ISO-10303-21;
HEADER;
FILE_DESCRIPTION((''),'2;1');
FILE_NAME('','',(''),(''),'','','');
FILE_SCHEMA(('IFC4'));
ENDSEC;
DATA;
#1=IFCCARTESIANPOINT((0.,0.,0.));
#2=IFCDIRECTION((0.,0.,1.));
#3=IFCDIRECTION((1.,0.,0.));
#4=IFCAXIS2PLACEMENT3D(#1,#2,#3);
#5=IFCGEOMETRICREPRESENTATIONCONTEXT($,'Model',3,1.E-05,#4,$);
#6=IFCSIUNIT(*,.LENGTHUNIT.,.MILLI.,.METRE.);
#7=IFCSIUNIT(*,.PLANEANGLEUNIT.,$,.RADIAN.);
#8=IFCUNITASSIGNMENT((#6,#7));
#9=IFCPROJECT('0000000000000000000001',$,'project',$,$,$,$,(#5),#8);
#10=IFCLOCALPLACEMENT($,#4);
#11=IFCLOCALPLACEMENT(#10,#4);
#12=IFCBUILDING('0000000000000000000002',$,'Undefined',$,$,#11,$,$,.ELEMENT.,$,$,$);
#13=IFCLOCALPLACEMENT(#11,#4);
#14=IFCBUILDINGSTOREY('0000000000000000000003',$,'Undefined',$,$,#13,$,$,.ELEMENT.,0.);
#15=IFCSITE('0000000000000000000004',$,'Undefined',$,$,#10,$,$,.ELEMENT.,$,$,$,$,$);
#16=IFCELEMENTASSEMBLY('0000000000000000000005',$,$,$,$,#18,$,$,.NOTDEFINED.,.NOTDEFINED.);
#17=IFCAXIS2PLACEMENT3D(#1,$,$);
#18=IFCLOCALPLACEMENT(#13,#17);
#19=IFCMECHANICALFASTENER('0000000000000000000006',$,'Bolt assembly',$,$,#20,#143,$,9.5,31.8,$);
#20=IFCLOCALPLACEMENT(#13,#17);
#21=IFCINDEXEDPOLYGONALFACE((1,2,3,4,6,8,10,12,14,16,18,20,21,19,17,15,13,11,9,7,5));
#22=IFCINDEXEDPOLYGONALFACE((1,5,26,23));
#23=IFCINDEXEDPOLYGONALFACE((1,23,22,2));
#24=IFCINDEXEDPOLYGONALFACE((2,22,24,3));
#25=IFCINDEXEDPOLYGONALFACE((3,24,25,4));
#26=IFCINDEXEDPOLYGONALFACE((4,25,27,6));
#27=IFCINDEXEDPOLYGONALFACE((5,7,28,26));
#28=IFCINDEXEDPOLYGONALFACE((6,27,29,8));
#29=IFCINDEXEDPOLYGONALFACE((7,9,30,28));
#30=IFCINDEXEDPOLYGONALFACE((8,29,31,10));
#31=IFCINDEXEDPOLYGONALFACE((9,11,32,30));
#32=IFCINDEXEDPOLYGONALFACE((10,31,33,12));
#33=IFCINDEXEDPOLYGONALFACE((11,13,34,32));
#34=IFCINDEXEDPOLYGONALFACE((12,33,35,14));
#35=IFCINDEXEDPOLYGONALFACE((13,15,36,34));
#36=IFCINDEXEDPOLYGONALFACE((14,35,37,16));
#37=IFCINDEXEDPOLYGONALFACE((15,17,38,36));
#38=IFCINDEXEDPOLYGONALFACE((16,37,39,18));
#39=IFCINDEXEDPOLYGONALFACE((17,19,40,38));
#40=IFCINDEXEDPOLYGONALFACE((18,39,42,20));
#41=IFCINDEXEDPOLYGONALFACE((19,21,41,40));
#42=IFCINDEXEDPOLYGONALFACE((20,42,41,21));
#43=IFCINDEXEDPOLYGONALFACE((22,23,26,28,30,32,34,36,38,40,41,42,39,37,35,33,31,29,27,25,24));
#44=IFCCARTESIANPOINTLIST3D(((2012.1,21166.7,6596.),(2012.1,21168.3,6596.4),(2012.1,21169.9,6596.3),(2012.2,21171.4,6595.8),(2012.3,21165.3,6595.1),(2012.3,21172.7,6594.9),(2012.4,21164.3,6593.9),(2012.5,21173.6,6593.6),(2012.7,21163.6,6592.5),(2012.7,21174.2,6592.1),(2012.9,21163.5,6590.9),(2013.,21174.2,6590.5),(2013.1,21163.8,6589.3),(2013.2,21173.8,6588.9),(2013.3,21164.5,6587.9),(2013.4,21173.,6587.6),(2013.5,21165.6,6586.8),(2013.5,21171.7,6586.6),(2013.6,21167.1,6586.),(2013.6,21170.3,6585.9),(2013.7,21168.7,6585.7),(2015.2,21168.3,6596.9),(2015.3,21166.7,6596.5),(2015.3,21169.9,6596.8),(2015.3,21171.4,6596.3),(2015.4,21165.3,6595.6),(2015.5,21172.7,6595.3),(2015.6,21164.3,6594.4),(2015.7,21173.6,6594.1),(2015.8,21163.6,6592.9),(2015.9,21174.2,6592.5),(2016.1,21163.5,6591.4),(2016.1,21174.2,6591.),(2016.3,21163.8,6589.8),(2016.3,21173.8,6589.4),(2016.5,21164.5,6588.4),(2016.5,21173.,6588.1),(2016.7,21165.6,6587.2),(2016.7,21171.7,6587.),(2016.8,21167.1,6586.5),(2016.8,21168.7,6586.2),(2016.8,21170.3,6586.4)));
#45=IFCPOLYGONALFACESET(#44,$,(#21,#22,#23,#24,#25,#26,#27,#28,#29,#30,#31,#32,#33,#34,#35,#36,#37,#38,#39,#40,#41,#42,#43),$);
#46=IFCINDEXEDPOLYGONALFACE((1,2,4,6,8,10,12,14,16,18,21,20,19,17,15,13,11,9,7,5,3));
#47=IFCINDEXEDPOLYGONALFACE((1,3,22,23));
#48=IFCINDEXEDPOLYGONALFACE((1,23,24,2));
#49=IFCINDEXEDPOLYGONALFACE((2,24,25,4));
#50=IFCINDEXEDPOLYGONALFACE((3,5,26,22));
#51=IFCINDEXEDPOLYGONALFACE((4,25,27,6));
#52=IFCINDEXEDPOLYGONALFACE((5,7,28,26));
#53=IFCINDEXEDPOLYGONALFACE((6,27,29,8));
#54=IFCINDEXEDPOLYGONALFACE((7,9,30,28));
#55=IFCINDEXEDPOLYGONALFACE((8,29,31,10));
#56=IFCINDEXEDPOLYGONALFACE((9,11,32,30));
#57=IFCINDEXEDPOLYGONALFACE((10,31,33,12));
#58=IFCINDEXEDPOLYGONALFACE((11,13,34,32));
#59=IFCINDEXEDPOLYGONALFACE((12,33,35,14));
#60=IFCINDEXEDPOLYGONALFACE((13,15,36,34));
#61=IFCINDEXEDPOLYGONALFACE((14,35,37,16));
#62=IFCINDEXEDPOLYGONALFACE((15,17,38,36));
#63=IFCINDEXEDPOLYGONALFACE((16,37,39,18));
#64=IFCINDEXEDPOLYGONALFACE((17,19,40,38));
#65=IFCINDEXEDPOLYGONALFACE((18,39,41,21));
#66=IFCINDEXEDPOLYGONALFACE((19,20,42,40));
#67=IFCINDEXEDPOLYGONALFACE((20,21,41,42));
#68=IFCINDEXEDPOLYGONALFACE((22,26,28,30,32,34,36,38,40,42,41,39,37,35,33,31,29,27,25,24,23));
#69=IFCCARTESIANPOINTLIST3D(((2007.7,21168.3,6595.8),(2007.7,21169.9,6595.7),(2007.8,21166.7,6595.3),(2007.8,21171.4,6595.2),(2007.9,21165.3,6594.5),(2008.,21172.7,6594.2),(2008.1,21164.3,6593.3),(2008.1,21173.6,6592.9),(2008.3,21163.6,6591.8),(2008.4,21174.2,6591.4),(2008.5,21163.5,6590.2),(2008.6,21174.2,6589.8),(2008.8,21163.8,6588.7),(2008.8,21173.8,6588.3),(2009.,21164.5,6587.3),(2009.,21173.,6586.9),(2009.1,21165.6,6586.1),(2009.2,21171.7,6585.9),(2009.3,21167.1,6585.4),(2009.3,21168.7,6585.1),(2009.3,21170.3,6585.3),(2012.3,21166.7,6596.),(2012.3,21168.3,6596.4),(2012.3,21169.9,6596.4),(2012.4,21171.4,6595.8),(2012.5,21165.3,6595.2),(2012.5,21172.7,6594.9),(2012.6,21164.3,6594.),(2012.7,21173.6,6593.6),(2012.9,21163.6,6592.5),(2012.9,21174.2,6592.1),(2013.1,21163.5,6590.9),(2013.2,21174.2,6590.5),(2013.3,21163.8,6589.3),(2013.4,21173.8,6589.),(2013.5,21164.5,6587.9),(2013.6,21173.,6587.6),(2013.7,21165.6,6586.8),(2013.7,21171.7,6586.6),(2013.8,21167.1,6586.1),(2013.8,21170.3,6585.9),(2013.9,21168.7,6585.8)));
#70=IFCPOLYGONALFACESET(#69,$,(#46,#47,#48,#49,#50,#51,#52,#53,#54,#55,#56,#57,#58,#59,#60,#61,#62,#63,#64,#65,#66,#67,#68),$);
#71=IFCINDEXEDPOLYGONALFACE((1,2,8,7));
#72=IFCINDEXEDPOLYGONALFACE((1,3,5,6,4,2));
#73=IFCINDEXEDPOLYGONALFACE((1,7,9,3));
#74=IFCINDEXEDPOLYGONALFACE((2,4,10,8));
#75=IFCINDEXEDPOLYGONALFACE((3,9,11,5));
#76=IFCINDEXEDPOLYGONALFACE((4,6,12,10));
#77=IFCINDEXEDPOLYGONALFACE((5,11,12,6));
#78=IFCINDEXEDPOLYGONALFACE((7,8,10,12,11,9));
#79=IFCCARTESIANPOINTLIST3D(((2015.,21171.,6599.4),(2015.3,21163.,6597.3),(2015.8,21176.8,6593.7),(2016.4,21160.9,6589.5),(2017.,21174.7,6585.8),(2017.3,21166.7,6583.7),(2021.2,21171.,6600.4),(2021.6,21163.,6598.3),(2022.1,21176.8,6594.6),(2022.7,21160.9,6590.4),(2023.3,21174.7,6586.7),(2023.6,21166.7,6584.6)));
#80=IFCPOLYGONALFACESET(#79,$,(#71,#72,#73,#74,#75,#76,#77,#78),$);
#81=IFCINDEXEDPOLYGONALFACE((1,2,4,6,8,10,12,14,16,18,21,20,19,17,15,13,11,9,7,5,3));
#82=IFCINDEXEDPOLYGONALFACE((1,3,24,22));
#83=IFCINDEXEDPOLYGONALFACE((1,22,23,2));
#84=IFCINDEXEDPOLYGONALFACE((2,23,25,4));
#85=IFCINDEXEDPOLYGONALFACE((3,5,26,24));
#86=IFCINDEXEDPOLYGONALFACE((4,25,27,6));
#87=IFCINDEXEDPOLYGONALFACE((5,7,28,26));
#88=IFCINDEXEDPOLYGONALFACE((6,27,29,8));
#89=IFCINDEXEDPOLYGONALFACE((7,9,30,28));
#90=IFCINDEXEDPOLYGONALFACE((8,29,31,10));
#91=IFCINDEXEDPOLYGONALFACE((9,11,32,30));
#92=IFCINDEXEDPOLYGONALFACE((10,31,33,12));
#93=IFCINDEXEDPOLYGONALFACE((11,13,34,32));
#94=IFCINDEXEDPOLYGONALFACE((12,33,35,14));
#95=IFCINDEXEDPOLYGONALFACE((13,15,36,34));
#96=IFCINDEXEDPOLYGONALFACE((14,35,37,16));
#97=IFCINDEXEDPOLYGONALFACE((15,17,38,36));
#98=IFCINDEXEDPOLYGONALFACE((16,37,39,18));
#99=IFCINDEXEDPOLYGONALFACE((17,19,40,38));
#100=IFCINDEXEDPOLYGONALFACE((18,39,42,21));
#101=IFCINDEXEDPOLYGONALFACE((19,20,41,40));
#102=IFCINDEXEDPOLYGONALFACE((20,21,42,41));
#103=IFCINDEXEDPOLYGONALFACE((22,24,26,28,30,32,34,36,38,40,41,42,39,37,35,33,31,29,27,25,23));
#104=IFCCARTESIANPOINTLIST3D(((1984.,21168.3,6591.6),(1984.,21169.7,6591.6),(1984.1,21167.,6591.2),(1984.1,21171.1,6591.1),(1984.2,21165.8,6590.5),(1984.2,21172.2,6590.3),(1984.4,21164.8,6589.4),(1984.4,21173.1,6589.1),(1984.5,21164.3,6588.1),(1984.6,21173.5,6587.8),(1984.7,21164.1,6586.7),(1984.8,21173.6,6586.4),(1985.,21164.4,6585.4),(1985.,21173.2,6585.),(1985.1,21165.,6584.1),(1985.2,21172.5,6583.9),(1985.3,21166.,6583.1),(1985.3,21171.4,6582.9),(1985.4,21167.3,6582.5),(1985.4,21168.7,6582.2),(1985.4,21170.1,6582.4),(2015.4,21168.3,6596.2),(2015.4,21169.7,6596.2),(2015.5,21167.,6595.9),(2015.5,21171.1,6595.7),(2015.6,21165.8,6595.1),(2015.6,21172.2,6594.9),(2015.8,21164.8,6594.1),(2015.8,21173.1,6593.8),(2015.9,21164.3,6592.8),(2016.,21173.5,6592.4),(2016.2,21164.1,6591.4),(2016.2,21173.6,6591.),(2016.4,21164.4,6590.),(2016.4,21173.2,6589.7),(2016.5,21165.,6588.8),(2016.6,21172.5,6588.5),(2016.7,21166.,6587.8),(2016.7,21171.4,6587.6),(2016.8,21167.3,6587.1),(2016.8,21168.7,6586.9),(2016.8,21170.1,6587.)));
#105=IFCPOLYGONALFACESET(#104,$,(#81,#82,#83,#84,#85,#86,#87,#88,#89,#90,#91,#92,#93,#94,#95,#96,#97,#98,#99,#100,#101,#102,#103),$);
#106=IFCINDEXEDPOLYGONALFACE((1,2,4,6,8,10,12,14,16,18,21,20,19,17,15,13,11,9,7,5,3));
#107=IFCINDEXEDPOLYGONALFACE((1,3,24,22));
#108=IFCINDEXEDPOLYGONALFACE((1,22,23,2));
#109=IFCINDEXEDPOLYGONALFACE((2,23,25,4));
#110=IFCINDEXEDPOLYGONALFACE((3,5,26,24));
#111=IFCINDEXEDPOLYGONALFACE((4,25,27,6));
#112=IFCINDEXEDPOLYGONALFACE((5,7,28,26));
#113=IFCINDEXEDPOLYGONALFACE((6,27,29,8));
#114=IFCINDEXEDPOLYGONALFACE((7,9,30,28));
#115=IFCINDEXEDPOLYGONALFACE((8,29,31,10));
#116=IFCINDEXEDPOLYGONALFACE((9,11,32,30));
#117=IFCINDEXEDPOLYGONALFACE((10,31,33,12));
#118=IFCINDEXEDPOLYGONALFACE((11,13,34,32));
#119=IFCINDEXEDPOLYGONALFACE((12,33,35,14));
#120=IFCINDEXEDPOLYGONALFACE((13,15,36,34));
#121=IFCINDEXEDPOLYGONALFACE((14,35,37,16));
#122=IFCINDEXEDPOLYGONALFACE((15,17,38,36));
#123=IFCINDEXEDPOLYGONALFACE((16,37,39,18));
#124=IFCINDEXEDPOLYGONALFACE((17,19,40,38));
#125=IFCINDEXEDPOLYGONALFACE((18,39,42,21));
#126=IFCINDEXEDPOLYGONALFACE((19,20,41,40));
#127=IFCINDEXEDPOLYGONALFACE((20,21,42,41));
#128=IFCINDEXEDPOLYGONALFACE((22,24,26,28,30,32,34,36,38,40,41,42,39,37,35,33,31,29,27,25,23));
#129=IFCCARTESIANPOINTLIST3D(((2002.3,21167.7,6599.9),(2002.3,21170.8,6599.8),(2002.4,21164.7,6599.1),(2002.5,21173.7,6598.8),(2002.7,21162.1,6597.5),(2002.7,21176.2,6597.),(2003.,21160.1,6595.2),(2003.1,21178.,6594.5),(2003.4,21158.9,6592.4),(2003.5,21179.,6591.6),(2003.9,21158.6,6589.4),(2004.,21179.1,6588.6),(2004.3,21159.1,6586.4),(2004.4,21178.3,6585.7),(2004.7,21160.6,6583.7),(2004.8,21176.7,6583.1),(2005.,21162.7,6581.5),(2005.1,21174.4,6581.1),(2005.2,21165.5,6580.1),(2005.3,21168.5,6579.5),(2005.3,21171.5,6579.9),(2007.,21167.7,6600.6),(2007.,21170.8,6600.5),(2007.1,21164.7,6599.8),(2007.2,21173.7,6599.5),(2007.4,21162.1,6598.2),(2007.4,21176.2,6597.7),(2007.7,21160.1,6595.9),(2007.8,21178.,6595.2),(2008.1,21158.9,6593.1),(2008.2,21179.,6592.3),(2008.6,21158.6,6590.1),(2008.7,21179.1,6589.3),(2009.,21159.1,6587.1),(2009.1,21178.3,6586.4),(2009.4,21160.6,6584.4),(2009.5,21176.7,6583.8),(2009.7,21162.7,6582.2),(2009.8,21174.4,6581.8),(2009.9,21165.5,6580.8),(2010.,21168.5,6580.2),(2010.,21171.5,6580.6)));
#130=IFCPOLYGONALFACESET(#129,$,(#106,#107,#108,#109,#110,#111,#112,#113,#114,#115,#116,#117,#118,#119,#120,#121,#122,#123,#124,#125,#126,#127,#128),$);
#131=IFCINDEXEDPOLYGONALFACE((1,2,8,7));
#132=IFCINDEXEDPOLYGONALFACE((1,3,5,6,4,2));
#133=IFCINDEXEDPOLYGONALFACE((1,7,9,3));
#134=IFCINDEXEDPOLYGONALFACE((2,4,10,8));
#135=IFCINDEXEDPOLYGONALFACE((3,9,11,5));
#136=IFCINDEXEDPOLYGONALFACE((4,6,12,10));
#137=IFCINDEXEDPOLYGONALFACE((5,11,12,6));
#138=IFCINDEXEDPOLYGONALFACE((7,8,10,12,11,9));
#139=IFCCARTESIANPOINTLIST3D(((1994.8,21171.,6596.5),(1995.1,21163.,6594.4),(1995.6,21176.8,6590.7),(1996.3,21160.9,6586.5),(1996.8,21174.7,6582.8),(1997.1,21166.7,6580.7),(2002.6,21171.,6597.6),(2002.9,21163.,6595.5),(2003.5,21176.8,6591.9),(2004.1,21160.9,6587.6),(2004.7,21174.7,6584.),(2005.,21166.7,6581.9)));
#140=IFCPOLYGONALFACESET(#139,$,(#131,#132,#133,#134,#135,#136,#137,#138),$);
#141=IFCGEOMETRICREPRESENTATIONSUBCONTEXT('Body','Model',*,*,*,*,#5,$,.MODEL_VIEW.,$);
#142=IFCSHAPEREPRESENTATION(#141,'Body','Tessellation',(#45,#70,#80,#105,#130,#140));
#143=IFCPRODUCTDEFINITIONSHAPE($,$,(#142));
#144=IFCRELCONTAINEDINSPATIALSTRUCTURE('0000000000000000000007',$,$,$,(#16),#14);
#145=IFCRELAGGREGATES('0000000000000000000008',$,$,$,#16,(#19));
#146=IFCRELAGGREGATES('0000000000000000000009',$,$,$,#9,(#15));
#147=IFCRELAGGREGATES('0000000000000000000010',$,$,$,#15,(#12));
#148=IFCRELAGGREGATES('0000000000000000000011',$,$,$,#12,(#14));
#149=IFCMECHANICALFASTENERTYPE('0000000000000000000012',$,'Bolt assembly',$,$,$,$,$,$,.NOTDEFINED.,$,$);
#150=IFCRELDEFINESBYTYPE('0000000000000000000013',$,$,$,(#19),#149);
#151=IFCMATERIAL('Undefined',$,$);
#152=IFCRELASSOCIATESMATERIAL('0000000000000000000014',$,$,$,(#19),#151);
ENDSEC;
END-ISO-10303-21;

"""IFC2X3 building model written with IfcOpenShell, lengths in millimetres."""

from ifc_helpers import new_model, si_unit, frame, origin_with_axes, origin_2d_with_axis, place, context, subcontext, project, spatial, polyline, circle, outline, extrude, source, transform, mapped, material, type_object, element, aggregate, save


model = new_model("IFC2X3")

# Units and contexts
model_context = context("Model", 3, precision=1e-05, world=origin_with_axes())
body_context = subcontext(model_context, "Body", "Model", "MODEL_VIEW")
ifc_project = project(units=[si_unit("LENGTHUNIT", "METRE", prefix="MILLI"), si_unit("PLANEANGLEUNIT", "RADIAN")], contexts=[model_context])

# Site, building, storey
site_placement = place(None, origin_with_axes())
site = spatial("IfcSite", under=ifc_project, at=site_placement, Name="Undefined", CompositionType="ELEMENT")
building_placement = place(site_placement, origin_with_axes())
building = spatial("IfcBuilding", under=site, at=building_placement, Name="Undefined", CompositionType="ELEMENT")
storey_placement = place(building_placement, origin_with_axes())
storey = spatial("IfcBuildingStorey", under=building, at=storey_placement, Name="Undefined", CompositionType="ELEMENT", Elevation=0.0)

# Element assembly
assembly_1_placement = place(storey_placement, origin_with_axes())
assembly_1 = element("IfcElementAssembly", 1, at=assembly_1_placement, inside=storey, AssemblyPlace="NOTDEFINED", PredefinedType="NOTDEFINED")

# Shared definitions
ifc_material_1 = material(Name="Undefined")
mechanical_fastener_type = type_object("IfcMechanicalFastenerType", Name="Bolt assembly")

# Mechanical fastener
shared_shape_1 = source(origin_with_axes(), body_context, "Body", "SweptSolid", [
    extrude(circle(Radius=5.4, at=origin_2d_with_axis()), frame((0.0, -3.1, 0.0), z_axis=(0.0, 1.0, 0.0), x_axis=(1.0, 0.0, 0.0)), (0.0, 0.0, 1.0), 3.2),
    extrude(circle(Radius=5.4, at=origin_2d_with_axis()), frame((0.0, -0.1, 0.0), z_axis=(0.0, 1.0, 0.0), x_axis=(1.0, 0.0, 0.0)), (0.0, 0.0, 1.0), 4.6),
    extrude(outline(polyline([(7.1, -4.1), (7.1, 4.1), (0.0, 8.2), (-7.1, 4.1), (-7.1, -4.1), (0.0, -8.2), (7.1, -4.1)])), frame((0.0, -9.6, 0.0), z_axis=(0.0, 1.0, 0.0), x_axis=(1.0, 0.0, 0.0)), (0.0, 0.0, 1.0), 6.3),
    extrude(circle(Radius=4.8, at=origin_2d_with_axis()), frame((0.0, -3.2, 0.0), z_axis=(0.0, 1.0, 0.0), x_axis=(1.0, 0.0, 0.0)), (0.0, 0.0, 1.0), 31.8),
    extrude(circle(Radius=10.3, at=origin_2d_with_axis()), frame((0.0, 4.5, 0.0), z_axis=(0.0, 1.0, 0.0), x_axis=(1.0, 0.0, 0.0)), (0.0, 0.0, 1.0), 4.8),
    extrude(outline(polyline([(7.1, -4.1), (7.1, 4.1), (0.0, 8.2), (-7.1, 4.1), (-7.1, -4.1), (0.0, -8.2), (7.1, -4.1)])), frame((0.0, 9.3, 0.0), z_axis=(0.0, 1.0, 0.0), x_axis=(1.0, 0.0, 0.0)), (0.0, 0.0, 1.0), 7.9),
])
mechanical_fastener_1_placement = place(assembly_1_placement, frame((2013.0, 21168.9, 6591.1), z_axis=(-0.103381, -0.707107, 0.699509), x_axis=(-0.103381, 0.707107, 0.699509)))
mechanical_fastener_1 = element("IfcMechanicalFastener", 2, at=mechanical_fastener_1_placement, type_object=mechanical_fastener_type, material=ifc_material_1, Name="Bolt assembly", NominalDiameter=9.5, NominalLength=31.8, context=body_context, shape_type="MappedRepresentation", body=[
    mapped(shared_shape_1, transform((0.0, 0.0, 0.0))),
])
aggregate(assembly_1, [mechanical_fastener_1])

save(model, "model.ifc")
